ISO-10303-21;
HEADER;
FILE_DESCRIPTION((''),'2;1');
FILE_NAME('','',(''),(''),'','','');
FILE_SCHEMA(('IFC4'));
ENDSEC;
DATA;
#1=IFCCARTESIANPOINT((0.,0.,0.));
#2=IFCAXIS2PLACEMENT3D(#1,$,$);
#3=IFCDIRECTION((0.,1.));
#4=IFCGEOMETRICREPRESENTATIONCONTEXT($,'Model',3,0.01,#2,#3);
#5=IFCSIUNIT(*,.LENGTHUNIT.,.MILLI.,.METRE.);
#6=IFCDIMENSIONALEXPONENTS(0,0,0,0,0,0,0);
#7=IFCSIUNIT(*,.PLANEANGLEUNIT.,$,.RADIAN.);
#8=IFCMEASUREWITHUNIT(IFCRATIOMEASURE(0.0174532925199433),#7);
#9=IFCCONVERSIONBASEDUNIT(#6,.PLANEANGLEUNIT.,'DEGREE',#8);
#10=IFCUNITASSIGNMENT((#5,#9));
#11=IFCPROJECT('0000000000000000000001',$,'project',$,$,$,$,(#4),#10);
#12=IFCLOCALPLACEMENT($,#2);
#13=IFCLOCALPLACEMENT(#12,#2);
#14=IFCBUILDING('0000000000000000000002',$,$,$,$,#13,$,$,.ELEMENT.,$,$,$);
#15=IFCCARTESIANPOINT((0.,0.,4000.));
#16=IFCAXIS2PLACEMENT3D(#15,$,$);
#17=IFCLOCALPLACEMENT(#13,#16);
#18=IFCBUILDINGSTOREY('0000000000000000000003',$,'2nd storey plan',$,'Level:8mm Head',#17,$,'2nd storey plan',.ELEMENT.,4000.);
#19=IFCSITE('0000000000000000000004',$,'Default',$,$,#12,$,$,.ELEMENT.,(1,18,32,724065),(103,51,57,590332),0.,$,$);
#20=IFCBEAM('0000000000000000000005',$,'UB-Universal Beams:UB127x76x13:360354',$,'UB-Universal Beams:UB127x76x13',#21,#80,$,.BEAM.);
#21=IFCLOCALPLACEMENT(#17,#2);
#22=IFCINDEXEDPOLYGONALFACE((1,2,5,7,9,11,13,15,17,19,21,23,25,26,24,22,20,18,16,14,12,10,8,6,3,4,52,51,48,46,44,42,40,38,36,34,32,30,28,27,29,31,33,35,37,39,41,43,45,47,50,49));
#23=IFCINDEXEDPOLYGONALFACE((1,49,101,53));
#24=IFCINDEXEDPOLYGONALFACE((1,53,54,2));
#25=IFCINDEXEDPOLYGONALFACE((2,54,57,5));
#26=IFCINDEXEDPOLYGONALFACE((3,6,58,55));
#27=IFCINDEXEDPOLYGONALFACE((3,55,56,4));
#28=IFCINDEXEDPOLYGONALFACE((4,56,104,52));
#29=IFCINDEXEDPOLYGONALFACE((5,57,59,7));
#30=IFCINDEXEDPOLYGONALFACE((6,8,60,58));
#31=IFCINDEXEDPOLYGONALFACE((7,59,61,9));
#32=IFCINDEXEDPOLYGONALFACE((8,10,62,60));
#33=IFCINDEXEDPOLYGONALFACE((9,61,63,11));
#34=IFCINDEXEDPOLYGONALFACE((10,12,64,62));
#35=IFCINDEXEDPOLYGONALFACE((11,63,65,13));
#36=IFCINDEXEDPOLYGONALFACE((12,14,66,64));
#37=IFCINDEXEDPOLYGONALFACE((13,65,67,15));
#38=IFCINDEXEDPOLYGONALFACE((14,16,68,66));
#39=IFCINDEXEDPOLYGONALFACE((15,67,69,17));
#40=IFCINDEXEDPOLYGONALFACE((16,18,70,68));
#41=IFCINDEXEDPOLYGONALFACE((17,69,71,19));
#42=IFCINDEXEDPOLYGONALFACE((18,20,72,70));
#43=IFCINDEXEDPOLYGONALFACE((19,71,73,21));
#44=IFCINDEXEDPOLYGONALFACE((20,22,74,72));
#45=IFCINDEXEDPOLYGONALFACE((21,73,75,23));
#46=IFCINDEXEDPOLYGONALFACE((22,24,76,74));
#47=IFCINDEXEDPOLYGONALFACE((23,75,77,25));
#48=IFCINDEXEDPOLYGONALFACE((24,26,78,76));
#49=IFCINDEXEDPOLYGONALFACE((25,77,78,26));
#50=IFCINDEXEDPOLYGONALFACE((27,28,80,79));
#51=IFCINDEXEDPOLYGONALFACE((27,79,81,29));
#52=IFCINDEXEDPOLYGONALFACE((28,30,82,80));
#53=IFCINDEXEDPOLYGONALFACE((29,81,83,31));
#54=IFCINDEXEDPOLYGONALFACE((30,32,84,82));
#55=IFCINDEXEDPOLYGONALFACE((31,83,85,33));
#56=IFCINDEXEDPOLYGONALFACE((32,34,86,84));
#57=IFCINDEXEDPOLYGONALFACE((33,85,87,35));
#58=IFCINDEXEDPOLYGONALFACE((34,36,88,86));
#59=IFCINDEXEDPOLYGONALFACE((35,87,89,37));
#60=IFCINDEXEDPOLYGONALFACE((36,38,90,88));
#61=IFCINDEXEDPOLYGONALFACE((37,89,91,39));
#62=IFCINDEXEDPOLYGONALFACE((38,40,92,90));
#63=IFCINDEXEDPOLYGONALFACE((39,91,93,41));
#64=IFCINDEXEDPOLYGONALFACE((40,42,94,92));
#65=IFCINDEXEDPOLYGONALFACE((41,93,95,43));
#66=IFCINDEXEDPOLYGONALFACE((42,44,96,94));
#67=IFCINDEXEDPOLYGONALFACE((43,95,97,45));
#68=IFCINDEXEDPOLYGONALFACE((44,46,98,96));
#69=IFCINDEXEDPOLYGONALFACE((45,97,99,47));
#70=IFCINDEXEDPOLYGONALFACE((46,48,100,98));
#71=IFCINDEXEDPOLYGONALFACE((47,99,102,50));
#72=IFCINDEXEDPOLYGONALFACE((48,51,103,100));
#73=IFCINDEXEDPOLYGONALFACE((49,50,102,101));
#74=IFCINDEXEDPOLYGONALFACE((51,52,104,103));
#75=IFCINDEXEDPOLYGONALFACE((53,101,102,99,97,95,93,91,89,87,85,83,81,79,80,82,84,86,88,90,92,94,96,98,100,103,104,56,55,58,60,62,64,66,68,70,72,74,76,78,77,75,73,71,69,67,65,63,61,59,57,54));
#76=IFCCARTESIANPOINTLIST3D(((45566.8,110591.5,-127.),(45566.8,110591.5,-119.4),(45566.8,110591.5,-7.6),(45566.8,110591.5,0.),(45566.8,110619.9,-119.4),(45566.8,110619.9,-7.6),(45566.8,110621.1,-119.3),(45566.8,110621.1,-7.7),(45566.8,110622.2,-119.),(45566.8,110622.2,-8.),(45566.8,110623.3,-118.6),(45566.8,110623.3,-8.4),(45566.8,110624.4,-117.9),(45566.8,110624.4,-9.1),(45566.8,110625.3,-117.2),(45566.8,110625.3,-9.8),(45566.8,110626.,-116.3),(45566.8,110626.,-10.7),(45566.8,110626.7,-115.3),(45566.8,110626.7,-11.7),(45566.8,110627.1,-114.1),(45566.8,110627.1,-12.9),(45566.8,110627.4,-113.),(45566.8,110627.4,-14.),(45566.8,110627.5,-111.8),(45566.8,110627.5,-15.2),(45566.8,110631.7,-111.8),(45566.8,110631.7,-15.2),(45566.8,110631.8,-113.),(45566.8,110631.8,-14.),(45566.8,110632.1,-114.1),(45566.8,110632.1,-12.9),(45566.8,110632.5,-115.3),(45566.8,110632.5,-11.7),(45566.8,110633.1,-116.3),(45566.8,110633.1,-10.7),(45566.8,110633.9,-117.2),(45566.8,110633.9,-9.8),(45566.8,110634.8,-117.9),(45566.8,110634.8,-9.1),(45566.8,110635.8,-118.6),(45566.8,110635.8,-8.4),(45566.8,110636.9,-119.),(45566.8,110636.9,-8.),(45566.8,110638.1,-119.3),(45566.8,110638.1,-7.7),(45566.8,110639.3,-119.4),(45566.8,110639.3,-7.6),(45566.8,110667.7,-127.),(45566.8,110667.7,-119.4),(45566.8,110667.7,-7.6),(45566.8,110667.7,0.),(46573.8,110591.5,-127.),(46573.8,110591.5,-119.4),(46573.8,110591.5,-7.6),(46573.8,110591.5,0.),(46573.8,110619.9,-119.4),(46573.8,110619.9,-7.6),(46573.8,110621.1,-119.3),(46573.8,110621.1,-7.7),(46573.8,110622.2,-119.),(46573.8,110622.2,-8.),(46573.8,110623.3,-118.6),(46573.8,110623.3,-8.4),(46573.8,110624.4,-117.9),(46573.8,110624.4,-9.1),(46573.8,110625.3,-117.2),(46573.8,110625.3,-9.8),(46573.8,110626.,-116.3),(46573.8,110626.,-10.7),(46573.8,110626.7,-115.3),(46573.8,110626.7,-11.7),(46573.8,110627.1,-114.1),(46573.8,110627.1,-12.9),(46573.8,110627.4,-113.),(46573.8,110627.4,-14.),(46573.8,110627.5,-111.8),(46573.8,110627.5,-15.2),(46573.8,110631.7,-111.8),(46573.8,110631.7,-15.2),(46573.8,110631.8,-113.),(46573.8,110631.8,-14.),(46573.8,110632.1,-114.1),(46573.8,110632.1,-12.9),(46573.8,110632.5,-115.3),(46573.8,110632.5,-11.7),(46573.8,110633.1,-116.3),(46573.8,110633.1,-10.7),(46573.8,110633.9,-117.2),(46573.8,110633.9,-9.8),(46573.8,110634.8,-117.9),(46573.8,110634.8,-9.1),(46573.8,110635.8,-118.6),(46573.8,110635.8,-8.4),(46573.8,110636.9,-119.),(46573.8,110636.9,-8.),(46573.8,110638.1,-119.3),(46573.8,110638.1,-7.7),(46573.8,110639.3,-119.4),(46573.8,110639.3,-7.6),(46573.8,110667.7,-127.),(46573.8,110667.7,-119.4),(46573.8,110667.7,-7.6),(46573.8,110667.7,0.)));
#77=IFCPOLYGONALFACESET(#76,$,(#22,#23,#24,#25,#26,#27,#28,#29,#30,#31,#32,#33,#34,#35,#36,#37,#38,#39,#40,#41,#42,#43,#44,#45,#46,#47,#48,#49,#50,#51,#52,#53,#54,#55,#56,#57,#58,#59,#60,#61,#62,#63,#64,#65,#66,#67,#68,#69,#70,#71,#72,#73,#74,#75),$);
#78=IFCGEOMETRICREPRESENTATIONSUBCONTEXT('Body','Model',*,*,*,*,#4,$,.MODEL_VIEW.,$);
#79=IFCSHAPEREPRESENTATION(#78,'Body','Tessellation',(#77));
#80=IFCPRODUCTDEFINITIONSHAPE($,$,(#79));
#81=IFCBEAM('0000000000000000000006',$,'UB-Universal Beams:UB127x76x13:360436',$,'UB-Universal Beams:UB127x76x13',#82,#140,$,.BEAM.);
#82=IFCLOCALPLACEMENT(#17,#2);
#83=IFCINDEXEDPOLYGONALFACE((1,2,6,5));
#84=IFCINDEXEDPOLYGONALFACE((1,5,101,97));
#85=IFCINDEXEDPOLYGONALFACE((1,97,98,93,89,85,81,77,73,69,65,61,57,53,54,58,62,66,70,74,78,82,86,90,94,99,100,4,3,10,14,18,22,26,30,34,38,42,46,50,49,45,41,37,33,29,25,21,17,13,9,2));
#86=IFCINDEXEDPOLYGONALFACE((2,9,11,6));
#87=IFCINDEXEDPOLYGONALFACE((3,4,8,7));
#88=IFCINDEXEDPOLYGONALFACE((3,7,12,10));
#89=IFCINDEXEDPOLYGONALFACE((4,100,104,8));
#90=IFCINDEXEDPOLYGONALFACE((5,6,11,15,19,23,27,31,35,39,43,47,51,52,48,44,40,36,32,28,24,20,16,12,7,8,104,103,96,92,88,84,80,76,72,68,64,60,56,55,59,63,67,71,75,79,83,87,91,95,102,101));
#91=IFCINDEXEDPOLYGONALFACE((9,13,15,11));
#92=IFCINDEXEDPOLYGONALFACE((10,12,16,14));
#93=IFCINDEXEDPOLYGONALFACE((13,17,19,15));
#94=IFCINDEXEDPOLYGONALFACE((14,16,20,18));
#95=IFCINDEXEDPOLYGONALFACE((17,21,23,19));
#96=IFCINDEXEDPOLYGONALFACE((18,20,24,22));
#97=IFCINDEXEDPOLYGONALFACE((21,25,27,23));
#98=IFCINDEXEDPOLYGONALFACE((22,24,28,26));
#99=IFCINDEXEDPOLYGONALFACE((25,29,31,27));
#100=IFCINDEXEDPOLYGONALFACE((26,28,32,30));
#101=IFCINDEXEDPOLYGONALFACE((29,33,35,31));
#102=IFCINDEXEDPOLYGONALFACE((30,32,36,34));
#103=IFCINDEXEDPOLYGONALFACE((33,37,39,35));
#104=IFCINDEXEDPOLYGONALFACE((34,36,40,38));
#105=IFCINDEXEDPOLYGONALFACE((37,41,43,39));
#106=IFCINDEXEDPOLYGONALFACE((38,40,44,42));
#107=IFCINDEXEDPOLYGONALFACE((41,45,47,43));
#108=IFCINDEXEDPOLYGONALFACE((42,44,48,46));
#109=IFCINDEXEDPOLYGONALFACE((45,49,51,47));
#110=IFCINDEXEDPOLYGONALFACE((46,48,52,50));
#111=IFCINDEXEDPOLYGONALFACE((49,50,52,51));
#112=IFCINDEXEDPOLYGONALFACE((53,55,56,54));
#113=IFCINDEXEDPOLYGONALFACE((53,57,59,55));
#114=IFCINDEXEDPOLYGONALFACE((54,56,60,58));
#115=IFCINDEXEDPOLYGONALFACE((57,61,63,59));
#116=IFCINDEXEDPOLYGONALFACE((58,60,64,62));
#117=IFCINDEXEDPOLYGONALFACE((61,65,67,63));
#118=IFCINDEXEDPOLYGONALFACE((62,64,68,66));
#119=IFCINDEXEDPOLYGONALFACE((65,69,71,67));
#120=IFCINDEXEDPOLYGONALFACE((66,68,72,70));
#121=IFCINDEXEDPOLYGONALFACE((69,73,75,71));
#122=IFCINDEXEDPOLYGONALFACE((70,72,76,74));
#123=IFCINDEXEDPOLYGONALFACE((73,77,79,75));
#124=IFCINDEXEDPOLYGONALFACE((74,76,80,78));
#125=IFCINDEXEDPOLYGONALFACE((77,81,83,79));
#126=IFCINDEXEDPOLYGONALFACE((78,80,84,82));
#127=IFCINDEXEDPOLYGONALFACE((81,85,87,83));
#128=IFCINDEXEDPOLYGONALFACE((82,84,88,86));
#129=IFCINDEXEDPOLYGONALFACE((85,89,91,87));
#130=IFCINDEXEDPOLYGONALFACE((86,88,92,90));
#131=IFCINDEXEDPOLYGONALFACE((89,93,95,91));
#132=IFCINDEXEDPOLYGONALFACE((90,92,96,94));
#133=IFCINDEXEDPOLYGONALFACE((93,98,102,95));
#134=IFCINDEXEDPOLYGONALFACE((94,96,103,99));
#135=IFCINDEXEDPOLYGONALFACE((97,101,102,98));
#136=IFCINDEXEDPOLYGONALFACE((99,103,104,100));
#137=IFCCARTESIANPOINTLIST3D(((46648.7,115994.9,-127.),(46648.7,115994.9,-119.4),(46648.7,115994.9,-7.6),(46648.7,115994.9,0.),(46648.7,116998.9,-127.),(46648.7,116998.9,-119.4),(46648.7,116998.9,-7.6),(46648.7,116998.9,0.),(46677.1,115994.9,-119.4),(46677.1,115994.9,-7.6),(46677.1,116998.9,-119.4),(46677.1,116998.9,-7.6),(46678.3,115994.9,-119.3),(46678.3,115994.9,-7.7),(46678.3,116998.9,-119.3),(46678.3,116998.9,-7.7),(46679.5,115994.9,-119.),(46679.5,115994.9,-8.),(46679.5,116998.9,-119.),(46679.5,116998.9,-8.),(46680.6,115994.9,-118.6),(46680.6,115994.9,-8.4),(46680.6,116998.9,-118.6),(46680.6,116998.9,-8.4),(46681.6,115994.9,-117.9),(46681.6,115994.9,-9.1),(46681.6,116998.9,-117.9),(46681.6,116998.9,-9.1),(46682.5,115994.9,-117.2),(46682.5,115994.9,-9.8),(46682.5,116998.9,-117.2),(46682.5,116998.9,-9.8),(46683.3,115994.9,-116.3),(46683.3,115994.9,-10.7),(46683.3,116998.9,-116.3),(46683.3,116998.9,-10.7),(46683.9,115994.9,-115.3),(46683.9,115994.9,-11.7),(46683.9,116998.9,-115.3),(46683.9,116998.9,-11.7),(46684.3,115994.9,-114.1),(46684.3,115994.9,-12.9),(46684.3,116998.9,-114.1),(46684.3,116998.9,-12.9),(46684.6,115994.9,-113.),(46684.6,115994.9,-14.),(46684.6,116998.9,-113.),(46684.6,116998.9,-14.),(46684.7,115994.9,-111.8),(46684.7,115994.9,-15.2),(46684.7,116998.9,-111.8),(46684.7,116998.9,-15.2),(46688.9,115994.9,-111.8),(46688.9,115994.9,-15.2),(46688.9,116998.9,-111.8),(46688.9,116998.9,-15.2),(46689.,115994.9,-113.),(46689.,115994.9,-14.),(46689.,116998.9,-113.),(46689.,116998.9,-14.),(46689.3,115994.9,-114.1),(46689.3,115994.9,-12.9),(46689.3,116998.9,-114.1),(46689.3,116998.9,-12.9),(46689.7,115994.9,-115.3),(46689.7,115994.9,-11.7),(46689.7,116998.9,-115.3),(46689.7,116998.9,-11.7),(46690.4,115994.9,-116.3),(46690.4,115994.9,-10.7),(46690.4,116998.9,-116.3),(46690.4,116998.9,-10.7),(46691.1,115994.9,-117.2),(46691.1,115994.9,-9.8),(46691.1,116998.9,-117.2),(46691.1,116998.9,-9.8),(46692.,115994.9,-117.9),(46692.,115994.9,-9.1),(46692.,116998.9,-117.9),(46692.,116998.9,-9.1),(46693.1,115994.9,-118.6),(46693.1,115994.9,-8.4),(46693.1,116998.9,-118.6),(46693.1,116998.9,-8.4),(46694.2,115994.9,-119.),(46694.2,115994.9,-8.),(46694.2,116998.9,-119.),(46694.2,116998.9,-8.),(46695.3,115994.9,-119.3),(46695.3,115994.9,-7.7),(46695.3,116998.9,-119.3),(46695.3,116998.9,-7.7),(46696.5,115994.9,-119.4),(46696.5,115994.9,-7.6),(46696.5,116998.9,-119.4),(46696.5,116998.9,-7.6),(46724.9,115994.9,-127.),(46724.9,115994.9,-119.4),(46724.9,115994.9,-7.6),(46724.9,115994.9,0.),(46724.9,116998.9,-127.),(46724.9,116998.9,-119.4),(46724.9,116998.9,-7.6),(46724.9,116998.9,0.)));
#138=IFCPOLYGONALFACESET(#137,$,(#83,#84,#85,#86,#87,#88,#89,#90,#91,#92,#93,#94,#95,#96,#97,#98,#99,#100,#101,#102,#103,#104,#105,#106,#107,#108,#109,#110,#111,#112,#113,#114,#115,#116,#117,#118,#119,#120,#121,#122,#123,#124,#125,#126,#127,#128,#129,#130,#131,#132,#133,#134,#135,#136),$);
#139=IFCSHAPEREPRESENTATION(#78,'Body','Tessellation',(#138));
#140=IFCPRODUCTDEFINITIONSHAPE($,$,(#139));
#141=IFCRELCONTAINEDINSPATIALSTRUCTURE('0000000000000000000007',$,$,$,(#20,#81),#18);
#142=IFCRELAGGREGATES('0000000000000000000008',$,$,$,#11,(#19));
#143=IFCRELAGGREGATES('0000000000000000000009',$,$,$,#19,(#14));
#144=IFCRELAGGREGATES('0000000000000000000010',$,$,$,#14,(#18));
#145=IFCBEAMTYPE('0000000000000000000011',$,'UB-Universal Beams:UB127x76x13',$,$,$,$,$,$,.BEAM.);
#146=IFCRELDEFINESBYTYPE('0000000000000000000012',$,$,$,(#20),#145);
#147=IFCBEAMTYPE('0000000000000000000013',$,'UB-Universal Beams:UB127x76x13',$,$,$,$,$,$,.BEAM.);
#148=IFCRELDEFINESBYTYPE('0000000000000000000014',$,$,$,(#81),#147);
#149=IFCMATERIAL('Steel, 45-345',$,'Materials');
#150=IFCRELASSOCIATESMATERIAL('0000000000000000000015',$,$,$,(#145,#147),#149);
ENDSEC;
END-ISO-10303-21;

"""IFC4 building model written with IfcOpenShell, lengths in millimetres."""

from ifc_helpers import new_model, entity, si_unit, converted_unit, direction, frame, origin, place, context, subcontext, project, spatial, indexed_curve, outline, extrude, source, transform, mapped, material, type_object, type_shapes, element, save


model = new_model("IFC4")

# Units and contexts
model_context = context("Model", 3, precision=0.01, world=origin(), true_north=direction((0.0, 1.0)))
body_context = subcontext(model_context, "Body", "Model", "MODEL_VIEW")
ifc_project = project(units=[si_unit("LENGTHUNIT", "METRE", prefix="MILLI"), converted_unit("PLANEANGLEUNIT", "DEGREE", entity("IfcRatioMeasure", 0.0174532925199433), si_unit("PLANEANGLEUNIT", "RADIAN"), dimensions=[0, 0, 0, 0, 0, 0, 0])], contexts=[model_context])

# Site, building, storey
site_placement = place(None, origin())
site = spatial("IfcSite", under=ifc_project, at=site_placement, Name="Default", CompositionType="ELEMENT", RefLatitude=(1, 18, 32, 724065), RefLongitude=(103, 51, 57, 590332), RefElevation=0.0)
building_placement = place(site_placement, origin())
building = spatial("IfcBuilding", under=site, at=building_placement, CompositionType="ELEMENT")
storey_placement = place(building_placement, frame((0.0, 0.0, 4000.0)))
storey = spatial("IfcBuildingStorey", under=building, at=storey_placement, Name="2nd storey plan", ObjectType="Level:8mm Head", LongName="2nd storey plan", CompositionType="ELEMENT", Elevation=4000.0)

# Beams
ifc_material_1 = material(Name="Steel, 45-345", Category="Materials")
beam_type_1 = type_object("IfcBeamType", Name="UB-Universal Beams:UB127x76x13", PredefinedType="BEAM", material=ifc_material_1)
shared_shape_1 = source(origin(), body_context, "Body", "SweptSolid", [
    extrude(outline(indexed_curve([(-63.5, -38.1), (-55.9, -38.1), (-55.9, -9.7), (-55.8, -8.5), (-55.5, -7.4), (-55.1, -6.2), (-54.4, -5.2), (-53.7, -4.3), (-52.8, -3.6), (-51.8, -2.9), (-50.6, -2.5), (-49.5, -2.2), (-48.3, -2.1), (48.3, -2.1), (49.5, -2.2), (50.6, -2.5), (51.8, -2.9), (52.8, -3.6), (53.7, -4.3), (54.4, -5.2), (55.1, -6.2), (55.5, -7.4), (55.8, -8.5), (55.9, -9.7), (55.9, -38.1), (63.5, -38.1), (63.5, 38.1), (55.9, 38.1), (55.9, 9.7), (55.8, 8.5), (55.5, 7.4), (55.1, 6.2), (54.4, 5.2), (53.7, 4.3), (52.8, 3.6), (51.8, 2.9), (50.6, 2.5), (49.5, 2.2), (48.3, 2.1), (-48.3, 2.1), (-49.5, 2.2), (-50.6, 2.5), (-51.8, 2.9), (-52.8, 3.6), (-53.7, 4.3), (-54.4, 5.2), (-55.1, 6.2), (-55.5, 7.4), (-55.8, 8.5), (-55.9, 9.7), (-55.9, 38.1), (-63.5, 38.1), (-63.5, -38.1)], self_intersect=False)), frame((-570.0, 0.0, 0.0), z_axis=(1.0, 0.0, 0.0), x_axis=(0.0, 0.0, -1.0)), (0.0, 0.0, 1.0), 1007.0),
])
type_shapes(beam_type_1, [shared_shape_1])
beam_1_placement = place(storey_placement, frame((46136.8, 110629.6, -63.5)))
element("IfcBeam", 1, at=beam_1_placement, inside=storey, type_object=beam_type_1, Name="UB-Universal Beams:UB127x76x13:360354", ObjectType="UB-Universal Beams:UB127x76x13", PredefinedType="BEAM", context=body_context, shape_type="MappedRepresentation", body=[
    mapped(shared_shape_1, transform((0.0, 0.0, 0.0), scale=1.0)),
])
beam_type_2 = type_object("IfcBeamType", Name="UB-Universal Beams:UB127x76x13", PredefinedType="BEAM", material=ifc_material_1)
shared_shape_2 = source(origin(), body_context, "Body", "SweptSolid", [
    extrude(outline(indexed_curve([(-63.5, -38.1), (-55.9, -38.1), (-55.9, -9.7), (-55.8, -8.5), (-55.5, -7.4), (-55.1, -6.2), (-54.4, -5.2), (-53.7, -4.3), (-52.8, -3.6), (-51.8, -2.9), (-50.6, -2.5), (-49.5, -2.2), (-48.3, -2.1), (48.3, -2.1), (49.5, -2.2), (50.6, -2.5), (51.8, -2.9), (52.8, -3.6), (53.7, -4.3), (54.4, -5.2), (55.1, -6.2), (55.5, -7.4), (55.8, -8.5), (55.9, -9.7), (55.9, -38.1), (63.5, -38.1), (63.5, 38.1), (55.9, 38.1), (55.9, 9.7), (55.8, 8.5), (55.5, 7.4), (55.1, 6.2), (54.4, 5.2), (53.7, 4.3), (52.8, 3.6), (51.8, 2.9), (50.6, 2.5), (49.5, 2.2), (48.3, 2.1), (-48.3, 2.1), (-49.5, 2.2), (-50.6, 2.5), (-51.8, 2.9), (-52.8, 3.6), (-53.7, 4.3), (-54.4, 5.2), (-55.1, 6.2), (-55.5, 7.4), (-55.8, 8.5), (-55.9, 9.7), (-55.9, 38.1), (-63.5, 38.1), (-63.5, -38.1)], self_intersect=False)), frame((-335.5, 0.0, 0.0), z_axis=(1.0, 0.0, 0.0), x_axis=(0.0, 0.0, -1.0)), (0.0, 0.0, 1.0), 1004.0),
])
type_shapes(beam_type_2, [shared_shape_2])
beam_2_placement = place(storey_placement, frame((46686.8, 116330.4, -63.5), z_axis=(0.0, 0.0, 1.0), x_axis=(0.0, 1.0, 0.0)))
element("IfcBeam", 2, at=beam_2_placement, inside=storey, type_object=beam_type_2, Name="UB-Universal Beams:UB127x76x13:360436", ObjectType="UB-Universal Beams:UB127x76x13", PredefinedType="BEAM", context=body_context, shape_type="MappedRepresentation", body=[
    mapped(shared_shape_2, transform((0.0, 0.0, 0.0), scale=1.0)),
])

save(model, "model.ifc")
